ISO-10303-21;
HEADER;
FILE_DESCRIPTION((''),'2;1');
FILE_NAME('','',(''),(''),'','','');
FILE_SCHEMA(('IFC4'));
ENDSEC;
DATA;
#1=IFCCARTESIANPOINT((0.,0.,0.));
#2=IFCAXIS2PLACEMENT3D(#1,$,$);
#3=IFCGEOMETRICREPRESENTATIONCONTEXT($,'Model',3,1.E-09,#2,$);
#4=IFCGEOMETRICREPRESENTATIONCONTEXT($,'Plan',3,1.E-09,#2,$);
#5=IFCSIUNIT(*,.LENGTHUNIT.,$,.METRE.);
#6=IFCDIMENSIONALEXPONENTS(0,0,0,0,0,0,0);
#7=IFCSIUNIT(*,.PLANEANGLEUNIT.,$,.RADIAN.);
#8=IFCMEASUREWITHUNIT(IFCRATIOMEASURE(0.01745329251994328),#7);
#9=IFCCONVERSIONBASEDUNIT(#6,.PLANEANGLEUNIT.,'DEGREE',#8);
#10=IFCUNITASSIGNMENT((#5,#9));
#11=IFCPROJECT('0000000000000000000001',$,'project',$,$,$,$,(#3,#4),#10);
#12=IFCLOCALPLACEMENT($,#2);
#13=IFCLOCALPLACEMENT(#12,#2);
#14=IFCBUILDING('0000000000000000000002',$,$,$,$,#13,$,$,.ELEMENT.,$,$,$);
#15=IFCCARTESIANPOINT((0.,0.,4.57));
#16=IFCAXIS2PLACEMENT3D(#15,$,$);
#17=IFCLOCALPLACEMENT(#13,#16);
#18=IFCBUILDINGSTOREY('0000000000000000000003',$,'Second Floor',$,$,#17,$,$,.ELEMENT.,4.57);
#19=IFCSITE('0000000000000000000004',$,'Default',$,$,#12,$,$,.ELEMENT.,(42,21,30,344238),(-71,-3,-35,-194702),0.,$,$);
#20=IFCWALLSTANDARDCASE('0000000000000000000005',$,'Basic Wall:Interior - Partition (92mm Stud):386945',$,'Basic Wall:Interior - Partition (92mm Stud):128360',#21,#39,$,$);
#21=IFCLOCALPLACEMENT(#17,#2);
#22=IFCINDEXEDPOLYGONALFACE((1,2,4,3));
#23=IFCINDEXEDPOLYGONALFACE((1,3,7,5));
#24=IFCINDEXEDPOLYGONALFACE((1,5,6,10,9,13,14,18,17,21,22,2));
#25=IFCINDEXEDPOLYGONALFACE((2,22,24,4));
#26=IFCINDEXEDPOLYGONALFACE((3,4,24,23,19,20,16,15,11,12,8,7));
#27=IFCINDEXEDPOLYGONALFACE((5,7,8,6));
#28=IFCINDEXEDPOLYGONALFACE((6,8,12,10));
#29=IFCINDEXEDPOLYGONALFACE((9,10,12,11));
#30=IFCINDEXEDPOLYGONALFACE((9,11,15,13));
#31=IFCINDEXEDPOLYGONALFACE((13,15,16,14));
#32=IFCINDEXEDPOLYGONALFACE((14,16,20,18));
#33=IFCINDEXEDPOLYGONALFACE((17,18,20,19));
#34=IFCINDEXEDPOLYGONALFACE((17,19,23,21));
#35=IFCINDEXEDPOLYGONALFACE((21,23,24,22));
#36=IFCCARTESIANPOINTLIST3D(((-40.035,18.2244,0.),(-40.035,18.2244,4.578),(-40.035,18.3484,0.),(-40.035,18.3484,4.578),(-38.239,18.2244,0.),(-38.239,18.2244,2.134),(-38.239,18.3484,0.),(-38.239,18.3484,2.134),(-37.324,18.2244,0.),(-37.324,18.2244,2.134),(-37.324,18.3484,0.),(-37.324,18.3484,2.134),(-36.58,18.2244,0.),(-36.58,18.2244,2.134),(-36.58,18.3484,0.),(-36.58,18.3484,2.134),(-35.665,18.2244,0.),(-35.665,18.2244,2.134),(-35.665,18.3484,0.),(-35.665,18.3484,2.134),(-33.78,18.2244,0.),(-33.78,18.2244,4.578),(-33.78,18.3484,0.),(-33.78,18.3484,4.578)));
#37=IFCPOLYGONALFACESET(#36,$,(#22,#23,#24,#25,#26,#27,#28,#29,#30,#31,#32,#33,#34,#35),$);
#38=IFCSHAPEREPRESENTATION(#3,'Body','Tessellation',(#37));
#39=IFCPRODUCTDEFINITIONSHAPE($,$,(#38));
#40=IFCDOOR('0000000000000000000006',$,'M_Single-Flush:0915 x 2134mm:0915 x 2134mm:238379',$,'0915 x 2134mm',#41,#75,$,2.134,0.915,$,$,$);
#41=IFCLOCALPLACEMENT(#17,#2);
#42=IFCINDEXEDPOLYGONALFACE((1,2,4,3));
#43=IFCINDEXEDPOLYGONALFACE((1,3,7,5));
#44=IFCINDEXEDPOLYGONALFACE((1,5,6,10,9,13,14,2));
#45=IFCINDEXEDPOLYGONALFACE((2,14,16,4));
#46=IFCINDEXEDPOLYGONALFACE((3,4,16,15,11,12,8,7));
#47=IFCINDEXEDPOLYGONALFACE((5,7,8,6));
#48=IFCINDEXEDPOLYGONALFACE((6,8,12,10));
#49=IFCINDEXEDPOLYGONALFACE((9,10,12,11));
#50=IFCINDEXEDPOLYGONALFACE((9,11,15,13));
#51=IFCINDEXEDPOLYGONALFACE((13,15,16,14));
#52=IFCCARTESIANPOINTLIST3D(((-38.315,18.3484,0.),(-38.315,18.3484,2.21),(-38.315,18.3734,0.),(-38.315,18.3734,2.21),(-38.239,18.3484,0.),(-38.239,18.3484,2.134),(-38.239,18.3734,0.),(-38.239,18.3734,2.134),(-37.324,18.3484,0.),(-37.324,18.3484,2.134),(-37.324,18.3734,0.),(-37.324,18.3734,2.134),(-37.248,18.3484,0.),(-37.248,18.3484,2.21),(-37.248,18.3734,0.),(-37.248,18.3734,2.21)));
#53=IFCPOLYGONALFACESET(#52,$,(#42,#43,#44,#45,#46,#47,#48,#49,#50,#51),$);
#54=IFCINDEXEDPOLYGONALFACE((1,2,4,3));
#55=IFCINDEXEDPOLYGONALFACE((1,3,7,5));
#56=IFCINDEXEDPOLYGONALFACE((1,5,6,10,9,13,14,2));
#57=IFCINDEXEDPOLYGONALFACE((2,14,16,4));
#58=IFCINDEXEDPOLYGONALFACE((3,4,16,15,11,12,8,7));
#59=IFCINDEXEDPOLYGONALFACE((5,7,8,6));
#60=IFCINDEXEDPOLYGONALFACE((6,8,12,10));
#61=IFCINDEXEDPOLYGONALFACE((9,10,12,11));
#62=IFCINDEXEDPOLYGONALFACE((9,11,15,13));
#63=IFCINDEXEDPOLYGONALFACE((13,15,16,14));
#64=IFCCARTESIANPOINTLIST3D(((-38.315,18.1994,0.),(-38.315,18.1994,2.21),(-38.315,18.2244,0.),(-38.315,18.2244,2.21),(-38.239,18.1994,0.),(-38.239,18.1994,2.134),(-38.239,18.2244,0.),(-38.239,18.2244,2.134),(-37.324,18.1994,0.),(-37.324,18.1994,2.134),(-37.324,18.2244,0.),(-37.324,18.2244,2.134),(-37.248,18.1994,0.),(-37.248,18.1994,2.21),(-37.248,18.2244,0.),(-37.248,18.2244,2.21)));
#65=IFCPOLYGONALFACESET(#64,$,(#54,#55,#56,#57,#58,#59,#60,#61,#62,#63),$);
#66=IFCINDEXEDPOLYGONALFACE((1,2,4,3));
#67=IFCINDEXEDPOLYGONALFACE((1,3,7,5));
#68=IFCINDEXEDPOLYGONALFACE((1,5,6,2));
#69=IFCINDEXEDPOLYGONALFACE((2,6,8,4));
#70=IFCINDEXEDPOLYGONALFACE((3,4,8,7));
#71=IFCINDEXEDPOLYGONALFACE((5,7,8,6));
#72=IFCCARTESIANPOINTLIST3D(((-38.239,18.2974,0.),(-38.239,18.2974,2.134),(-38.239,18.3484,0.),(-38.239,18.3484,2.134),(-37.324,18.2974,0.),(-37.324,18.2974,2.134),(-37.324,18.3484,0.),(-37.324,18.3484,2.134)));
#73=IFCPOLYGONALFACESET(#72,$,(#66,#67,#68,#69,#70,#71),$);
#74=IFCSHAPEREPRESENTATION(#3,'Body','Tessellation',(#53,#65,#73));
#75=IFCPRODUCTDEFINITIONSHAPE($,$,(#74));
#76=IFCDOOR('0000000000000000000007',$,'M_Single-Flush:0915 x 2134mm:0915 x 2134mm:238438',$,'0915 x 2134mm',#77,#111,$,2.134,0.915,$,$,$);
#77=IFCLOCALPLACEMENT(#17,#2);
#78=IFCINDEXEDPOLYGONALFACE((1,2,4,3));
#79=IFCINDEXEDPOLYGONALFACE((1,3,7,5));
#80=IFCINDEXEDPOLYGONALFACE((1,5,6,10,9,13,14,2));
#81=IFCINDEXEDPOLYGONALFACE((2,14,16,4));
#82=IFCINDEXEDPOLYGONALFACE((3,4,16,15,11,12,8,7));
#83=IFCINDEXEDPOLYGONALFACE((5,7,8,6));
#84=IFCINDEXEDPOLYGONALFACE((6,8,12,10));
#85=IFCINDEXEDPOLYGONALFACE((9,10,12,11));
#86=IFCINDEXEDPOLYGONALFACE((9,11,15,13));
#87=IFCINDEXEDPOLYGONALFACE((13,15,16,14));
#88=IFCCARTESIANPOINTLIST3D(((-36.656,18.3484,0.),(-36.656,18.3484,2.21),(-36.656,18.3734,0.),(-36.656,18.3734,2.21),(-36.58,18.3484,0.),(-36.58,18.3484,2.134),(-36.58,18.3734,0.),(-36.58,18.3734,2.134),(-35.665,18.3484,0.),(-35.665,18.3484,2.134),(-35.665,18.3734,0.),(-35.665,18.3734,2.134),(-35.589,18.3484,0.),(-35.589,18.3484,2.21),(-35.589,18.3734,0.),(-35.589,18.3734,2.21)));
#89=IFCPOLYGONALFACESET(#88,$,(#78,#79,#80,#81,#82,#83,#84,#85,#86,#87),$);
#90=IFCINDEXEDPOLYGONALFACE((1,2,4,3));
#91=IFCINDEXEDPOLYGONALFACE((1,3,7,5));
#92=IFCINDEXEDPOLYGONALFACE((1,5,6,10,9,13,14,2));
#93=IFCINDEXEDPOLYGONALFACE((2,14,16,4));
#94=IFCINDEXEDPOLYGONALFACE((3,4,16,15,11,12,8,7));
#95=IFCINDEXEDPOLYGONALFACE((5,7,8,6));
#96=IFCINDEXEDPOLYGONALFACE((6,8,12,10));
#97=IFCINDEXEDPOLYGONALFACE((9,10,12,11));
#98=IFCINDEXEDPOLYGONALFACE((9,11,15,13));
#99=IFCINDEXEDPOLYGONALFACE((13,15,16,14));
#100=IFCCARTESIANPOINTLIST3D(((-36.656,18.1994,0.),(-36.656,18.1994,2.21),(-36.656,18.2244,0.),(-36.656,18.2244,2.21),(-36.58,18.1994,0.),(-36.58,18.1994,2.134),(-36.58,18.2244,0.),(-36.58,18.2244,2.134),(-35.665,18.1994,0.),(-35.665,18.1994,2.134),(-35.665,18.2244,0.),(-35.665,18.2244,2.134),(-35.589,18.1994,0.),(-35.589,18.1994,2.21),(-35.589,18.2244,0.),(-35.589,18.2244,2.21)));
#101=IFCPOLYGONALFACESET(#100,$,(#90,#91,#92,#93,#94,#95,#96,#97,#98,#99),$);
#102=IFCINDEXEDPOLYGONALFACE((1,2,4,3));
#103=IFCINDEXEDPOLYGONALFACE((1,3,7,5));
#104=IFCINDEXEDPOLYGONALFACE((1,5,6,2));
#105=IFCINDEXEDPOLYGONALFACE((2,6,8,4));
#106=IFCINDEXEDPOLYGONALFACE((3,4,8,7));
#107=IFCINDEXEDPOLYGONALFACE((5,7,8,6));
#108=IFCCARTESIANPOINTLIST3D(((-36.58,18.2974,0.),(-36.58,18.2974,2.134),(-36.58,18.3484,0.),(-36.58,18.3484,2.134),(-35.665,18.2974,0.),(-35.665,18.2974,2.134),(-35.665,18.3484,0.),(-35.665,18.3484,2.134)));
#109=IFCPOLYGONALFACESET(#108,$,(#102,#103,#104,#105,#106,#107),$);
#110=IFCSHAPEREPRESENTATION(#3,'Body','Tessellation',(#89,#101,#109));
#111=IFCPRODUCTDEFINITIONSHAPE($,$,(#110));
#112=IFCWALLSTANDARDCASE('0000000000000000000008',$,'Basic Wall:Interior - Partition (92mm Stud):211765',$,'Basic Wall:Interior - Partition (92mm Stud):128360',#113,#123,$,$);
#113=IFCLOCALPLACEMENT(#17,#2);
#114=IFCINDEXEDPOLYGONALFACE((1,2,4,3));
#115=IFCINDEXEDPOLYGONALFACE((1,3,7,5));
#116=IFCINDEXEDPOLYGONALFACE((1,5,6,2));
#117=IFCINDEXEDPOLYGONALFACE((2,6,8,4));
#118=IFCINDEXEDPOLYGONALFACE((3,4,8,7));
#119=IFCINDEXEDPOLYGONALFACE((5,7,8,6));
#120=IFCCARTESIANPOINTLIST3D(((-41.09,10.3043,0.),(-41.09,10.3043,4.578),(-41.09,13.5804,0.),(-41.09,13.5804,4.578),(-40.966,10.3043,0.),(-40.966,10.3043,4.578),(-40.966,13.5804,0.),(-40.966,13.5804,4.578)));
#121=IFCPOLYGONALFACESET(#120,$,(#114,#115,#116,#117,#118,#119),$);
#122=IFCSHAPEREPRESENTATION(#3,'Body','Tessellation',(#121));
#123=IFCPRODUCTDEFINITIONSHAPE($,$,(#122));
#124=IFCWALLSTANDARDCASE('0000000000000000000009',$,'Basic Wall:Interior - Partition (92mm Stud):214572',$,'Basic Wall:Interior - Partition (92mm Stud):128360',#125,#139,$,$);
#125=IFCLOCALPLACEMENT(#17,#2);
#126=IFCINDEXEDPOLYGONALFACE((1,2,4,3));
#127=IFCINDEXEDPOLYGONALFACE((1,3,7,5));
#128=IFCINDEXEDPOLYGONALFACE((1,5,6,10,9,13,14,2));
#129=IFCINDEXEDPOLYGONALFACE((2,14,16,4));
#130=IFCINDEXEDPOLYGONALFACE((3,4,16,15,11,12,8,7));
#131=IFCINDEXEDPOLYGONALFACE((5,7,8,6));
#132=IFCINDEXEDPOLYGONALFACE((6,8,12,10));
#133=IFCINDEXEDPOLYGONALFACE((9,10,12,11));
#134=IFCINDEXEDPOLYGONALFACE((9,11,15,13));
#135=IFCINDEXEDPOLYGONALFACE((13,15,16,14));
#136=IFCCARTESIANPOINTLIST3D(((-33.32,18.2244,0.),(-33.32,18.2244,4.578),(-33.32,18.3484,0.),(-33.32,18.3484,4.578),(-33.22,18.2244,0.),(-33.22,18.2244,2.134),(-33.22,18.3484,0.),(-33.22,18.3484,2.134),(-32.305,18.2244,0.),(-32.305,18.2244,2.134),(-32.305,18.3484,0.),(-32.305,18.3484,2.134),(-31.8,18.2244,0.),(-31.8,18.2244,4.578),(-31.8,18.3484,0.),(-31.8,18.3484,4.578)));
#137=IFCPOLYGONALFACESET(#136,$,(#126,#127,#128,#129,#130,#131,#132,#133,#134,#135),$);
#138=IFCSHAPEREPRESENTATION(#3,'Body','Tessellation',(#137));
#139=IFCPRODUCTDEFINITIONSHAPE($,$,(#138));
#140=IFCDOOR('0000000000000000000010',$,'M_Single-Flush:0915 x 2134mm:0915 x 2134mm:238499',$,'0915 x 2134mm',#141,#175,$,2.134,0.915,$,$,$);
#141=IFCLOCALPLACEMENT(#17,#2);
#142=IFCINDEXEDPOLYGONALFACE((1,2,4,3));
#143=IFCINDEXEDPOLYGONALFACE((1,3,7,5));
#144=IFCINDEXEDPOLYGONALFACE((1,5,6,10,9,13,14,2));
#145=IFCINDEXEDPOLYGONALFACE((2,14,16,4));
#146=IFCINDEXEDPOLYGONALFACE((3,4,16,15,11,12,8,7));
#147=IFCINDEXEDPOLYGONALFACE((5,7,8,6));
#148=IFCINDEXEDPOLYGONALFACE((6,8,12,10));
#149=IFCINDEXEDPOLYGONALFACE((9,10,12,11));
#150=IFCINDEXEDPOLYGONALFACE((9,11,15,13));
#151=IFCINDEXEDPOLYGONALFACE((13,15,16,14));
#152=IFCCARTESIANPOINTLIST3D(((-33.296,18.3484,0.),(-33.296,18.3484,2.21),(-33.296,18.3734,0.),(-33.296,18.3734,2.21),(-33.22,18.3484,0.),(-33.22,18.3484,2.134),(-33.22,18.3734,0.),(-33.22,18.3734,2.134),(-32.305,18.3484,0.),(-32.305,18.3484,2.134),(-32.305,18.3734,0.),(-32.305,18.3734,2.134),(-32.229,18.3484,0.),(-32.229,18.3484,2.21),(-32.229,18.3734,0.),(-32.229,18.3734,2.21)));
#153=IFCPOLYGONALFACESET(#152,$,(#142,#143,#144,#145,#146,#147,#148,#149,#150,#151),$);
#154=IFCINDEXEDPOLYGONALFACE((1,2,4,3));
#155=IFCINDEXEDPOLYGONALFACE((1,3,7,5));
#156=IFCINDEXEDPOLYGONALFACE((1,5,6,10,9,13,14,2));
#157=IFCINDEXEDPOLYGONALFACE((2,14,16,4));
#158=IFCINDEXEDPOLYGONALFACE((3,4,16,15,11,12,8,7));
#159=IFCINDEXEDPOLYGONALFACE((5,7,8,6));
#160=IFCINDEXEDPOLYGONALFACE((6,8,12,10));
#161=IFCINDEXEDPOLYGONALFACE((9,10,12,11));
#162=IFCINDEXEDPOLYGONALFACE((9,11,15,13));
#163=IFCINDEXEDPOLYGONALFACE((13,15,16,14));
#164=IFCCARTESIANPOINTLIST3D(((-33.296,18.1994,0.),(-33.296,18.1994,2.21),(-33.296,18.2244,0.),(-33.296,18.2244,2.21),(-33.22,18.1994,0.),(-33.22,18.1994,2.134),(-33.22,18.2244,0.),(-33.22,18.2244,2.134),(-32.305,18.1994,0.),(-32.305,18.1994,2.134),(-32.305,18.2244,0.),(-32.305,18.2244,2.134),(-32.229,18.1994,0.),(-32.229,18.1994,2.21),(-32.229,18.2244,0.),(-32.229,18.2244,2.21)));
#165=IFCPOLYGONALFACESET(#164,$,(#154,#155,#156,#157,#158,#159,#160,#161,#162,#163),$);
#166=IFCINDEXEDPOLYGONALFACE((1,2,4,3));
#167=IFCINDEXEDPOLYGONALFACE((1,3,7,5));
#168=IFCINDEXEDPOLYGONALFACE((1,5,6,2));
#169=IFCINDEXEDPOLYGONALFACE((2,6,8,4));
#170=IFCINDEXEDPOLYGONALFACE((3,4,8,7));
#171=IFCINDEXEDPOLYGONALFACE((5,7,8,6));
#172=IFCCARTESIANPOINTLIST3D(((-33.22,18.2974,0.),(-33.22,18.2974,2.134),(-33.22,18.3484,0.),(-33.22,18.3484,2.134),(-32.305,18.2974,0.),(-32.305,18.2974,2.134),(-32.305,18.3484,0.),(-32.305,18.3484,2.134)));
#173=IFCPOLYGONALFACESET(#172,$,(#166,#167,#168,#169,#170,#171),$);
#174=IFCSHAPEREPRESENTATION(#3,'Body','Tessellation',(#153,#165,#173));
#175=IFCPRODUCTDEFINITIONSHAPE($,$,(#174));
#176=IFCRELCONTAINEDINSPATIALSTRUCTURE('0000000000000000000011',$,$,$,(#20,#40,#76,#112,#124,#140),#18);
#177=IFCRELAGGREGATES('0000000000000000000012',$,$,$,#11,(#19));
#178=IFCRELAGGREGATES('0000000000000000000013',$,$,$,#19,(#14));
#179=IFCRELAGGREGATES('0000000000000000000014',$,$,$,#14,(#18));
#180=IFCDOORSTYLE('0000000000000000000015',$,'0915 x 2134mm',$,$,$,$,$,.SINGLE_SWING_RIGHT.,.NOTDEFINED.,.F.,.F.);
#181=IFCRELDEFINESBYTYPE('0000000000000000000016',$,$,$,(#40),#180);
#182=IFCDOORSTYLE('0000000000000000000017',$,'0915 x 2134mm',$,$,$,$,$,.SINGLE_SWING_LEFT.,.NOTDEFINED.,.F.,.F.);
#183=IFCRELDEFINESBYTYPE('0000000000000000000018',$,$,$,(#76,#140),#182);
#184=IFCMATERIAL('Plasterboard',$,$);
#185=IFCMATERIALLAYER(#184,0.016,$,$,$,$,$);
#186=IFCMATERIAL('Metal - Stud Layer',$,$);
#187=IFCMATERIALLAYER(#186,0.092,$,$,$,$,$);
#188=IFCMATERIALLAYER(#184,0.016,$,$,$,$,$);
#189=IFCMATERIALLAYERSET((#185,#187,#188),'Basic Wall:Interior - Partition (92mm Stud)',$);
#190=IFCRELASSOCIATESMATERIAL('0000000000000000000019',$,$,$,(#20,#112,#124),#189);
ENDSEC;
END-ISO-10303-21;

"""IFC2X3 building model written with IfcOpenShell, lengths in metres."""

from ifc_helpers import new_model, entity, si_unit, converted_unit, frame, frame_2d, origin, origin_2d_with_axis, place, context, project, spatial, polyline, rectangle, outline, extrude, source, transform, mapped, material, layer, layer_set, layer_usage, type_object, type_shapes, element, fill, save


model = new_model("IFC2X3")

# Units and contexts
model_context = context("Model", 3, precision=1e-09, world=origin())
plan_context = context("Plan", 3, precision=1e-09, world=origin())
ifc_project = project(units=[si_unit("LENGTHUNIT", "METRE"), converted_unit("PLANEANGLEUNIT", "DEGREE", entity("IfcRatioMeasure", 0.01745329251994328), si_unit("PLANEANGLEUNIT", "RADIAN"), dimensions=[0, 0, 0, 0, 0, 0, 0])], contexts=[model_context, plan_context])

# Site, building, storey
site_placement = place(None, origin())
site = spatial("IfcSite", under=ifc_project, at=site_placement, Name="Default", CompositionType="ELEMENT", RefLatitude=(42, 21, 30, 344238), RefLongitude=(-71, -3, -35, -194702), RefElevation=0.0)
building_placement = place(site_placement, origin())
building = spatial("IfcBuilding", under=site, at=building_placement, CompositionType="ELEMENT")
storey_placement = place(building_placement, frame((0.0, 0.0, 4.57)))
storey = spatial("IfcBuildingStorey", under=building, at=storey_placement, Name="Second Floor", CompositionType="ELEMENT", Elevation=4.57)

# Wall, openings, doors
ifc_material_1 = material(Name="Plasterboard")
ifc_layer_1 = layer(ifc_material_1, 0.016)
ifc_material_2 = material(Name="Metal - Stud Layer")
ifc_layer_2 = layer(ifc_material_2, 0.092)
ifc_layer_3 = layer(ifc_material_1, 0.016)
ifc_layer_set_1 = layer_set([ifc_layer_1, ifc_layer_2, ifc_layer_3], Name="Basic Wall:Interior - Partition (92mm Stud)")
ifc_layer_usage_1 = layer_usage(ifc_layer_set_1, "AXIS2", "NEGATIVE", 0.062)
wall_1_placement = place(storey_placement, frame((-33.78, 18.2864, 0.0), z_axis=(0.0, 0.0, 1.0), x_axis=(-1.0, 0.0, 0.0)))
wall_1 = element("IfcWallStandardCase", 1, at=wall_1_placement, inside=storey, material=ifc_layer_usage_1, Name="Basic Wall:Interior - Partition (92mm Stud):386945", ObjectType="Basic Wall:Interior - Partition (92mm Stud):128360", context=model_context, shape_type="SweptSolid", body=[
    extrude(rectangle(XDim=6.255, YDim=0.124, at=frame_2d((3.1275, 0.0), x_axis=(-1.0, 0.0))), origin(), (0.0, 0.0, 1.0), 4.578),
])
opening_1_placement = place(wall_1_placement, frame((2.8, 0.062, 0.0)))
opening_1 = element("IfcOpeningElement", 2, at=opening_1_placement, cuts=wall_1, ObjectType="Opening", context=model_context, shape_type="SweptSolid", body=[
    extrude(rectangle(XDim=0.915, YDim=2.134, at=frame_2d((1.067, 0.4575), x_axis=(0.0, -1.0))), frame((0.0, 0.0, 0.0), z_axis=(0.0, -1.0, 0.0), x_axis=(0.0, 0.0, 1.0)), (0.0, 0.0, 1.0), 0.124),
])
opening_2_placement = place(wall_1_placement, frame((4.459, 0.062, 0.0)))
opening_2 = element("IfcOpeningElement", 3, at=opening_2_placement, cuts=wall_1, ObjectType="Opening", context=model_context, shape_type="SweptSolid", body=[
    extrude(rectangle(XDim=0.915, YDim=2.134, at=frame_2d((1.067, 0.4575), x_axis=(0.0, 1.0))), frame((0.0, 0.0, 0.0), z_axis=(0.0, -1.0, 0.0), x_axis=(0.0, 0.0, 1.0)), (0.0, 0.0, 1.0), 0.124),
])
door_style_1 = type_object("IfcDoorStyle", Name="0915 x 2134mm", ConstructionType="NOTDEFINED", OperationType="SINGLE_SWING_RIGHT", ParameterTakesPrecedence=False, Sizeable=False)
shared_shape_1 = source(origin(), model_context, "Body", "SweptSolid", [
    extrude(outline(polyline([(-0.5335, -1.124), (0.5335, -1.124), (0.5335, 1.086), (0.4575, 1.086), (0.4575, -1.048), (-0.4575, -1.048), (-0.4575, 1.086), (-0.5335, 1.086), (-0.5335, -1.124)])), frame((0.4575, 0.124, 1.086), z_axis=(0.0, 1.0, 0.0), x_axis=(1.0, 0.0, 0.0)), (0.0, 0.0, 1.0), 0.025),
    extrude(outline(polyline([(-1.124, -0.5335), (1.086, -0.5335), (1.086, -0.4575), (-1.048, -0.4575), (-1.048, 0.4575), (1.086, 0.4575), (1.086, 0.5335), (-1.124, 0.5335), (-1.124, -0.5335)])), frame((0.4575, -0.025, 1.086), z_axis=(0.0, 1.0, 0.0), x_axis=(0.0, 0.0, -1.0)), (0.0, 0.0, 1.0), 0.025),
    extrude(rectangle(XDim=0.051, YDim=0.915, at=origin_2d_with_axis()), frame((0.4575, 0.0985, 0.0), z_axis=(0.0, 0.0, 1.0), x_axis=(0.0, 1.0, 0.0)), (0.0, 0.0, 1.0), 2.134),
])
type_shapes(door_style_1, [shared_shape_1])
door_1_placement = place(opening_2_placement, frame((0.0, 0.0, 0.0), z_axis=(0.0, 0.0, 1.0), x_axis=(-1.0, 0.0, 0.0)))
door_1 = element("IfcDoor", 4, at=door_1_placement, inside=storey, type_object=door_style_1, Name="M_Single-Flush:0915 x 2134mm:0915 x 2134mm:238379", ObjectType="0915 x 2134mm", OverallHeight=2.134, OverallWidth=0.915, context=model_context, shape_type="MappedRepresentation", body=[
    mapped(shared_shape_1, transform((0.0, 0.0, 0.0), scale=1.0)),
])
fill(opening_2, door_1)
door_style_2 = type_object("IfcDoorStyle", Name="0915 x 2134mm", ConstructionType="NOTDEFINED", OperationType="SINGLE_SWING_LEFT", ParameterTakesPrecedence=False, Sizeable=False)
shared_shape_2 = source(origin(), model_context, "Body", "SweptSolid", [
    extrude(outline(polyline([(-0.5335, -1.124), (0.5335, -1.124), (0.5335, 1.086), (0.4575, 1.086), (0.4575, -1.048), (-0.4575, -1.048), (-0.4575, 1.086), (-0.5335, 1.086), (-0.5335, -1.124)])), frame((0.4575, 0.149, 1.086), z_axis=(0.0, -1.0, 0.0), x_axis=(-1.0, 0.0, 0.0)), (0.0, 0.0, 1.0), 0.025),
    extrude(outline(polyline([(-1.124, -0.5335), (1.086, -0.5335), (1.086, -0.4575), (-1.048, -0.4575), (-1.048, 0.4575), (1.086, 0.4575), (1.086, 0.5335), (-1.124, 0.5335), (-1.124, -0.5335)])), frame((0.4575, 0.0, 1.086), z_axis=(0.0, -1.0, 0.0), x_axis=(0.0, 0.0, -1.0)), (0.0, 0.0, 1.0), 0.025),
    extrude(rectangle(XDim=0.915, YDim=0.051, at=origin_2d_with_axis()), frame((0.4575, 0.0985, 0.0)), (0.0, 0.0, 1.0), 2.134),
])
type_shapes(door_style_2, [shared_shape_2])
door_2_placement = place(opening_1_placement, frame((0.0, 0.0, 0.0), z_axis=(0.0, 0.0, 1.0), x_axis=(-1.0, 0.0, 0.0)))
door_2 = element("IfcDoor", 5, at=door_2_placement, inside=storey, type_object=door_style_2, Name="M_Single-Flush:0915 x 2134mm:0915 x 2134mm:238438", ObjectType="0915 x 2134mm", OverallHeight=2.134, OverallWidth=0.915, context=model_context, shape_type="MappedRepresentation", body=[
    mapped(shared_shape_2, transform((0.0, 0.0, 0.0), scale=1.0)),
])
fill(opening_1, door_2)

# Wall
wall_2_placement = place(storey_placement, frame((-41.028, 10.3043, 0.0), z_axis=(0.0, 0.0, 1.0), x_axis=(0.0, 1.0, 0.0)))
element("IfcWallStandardCase", 6, at=wall_2_placement, inside=storey, material=ifc_layer_usage_1, Name="Basic Wall:Interior - Partition (92mm Stud):211765", ObjectType="Basic Wall:Interior - Partition (92mm Stud):128360", context=model_context, shape_type="SweptSolid", body=[
    extrude(rectangle(XDim=3.2761, YDim=0.124, at=frame_2d((1.6381, 0.0), x_axis=(-1.0, 0.0))), origin(), (0.0, 0.0, 1.0), 4.578),
])

# Wall, opening, door
wall_3_placement = place(storey_placement, frame((-31.8, 18.2864, 0.0), z_axis=(0.0, 0.0, 1.0), x_axis=(-1.0, 0.0, 0.0)))
wall_3 = element("IfcWallStandardCase", 7, at=wall_3_placement, inside=storey, material=ifc_layer_usage_1, Name="Basic Wall:Interior - Partition (92mm Stud):214572", ObjectType="Basic Wall:Interior - Partition (92mm Stud):128360", context=model_context, shape_type="SweptSolid", body=[
    extrude(rectangle(XDim=1.52, YDim=0.124, at=frame_2d((0.76, 0.0), x_axis=(-1.0, 0.0))), origin(), (0.0, 0.0, 1.0), 4.578),
])
opening_3_placement = place(wall_3_placement, frame((1.42, 0.062, 0.0)))
opening_3 = element("IfcOpeningElement", 8, at=opening_3_placement, cuts=wall_3, ObjectType="Opening", context=model_context, shape_type="SweptSolid", body=[
    extrude(rectangle(XDim=0.915, YDim=2.134, at=frame_2d((1.067, 0.4575), x_axis=(0.0, -1.0))), frame((0.0, 0.0, 0.0), z_axis=(0.0, -1.0, 0.0), x_axis=(0.0, 0.0, 1.0)), (0.0, 0.0, 1.0), 0.124),
])
door_3_placement = place(opening_3_placement, frame((0.0, 0.0, 0.0), z_axis=(0.0, 0.0, 1.0), x_axis=(-1.0, 0.0, 0.0)))
door_3 = element("IfcDoor", 9, at=door_3_placement, inside=storey, type_object=door_style_2, Name="M_Single-Flush:0915 x 2134mm:0915 x 2134mm:238499", ObjectType="0915 x 2134mm", OverallHeight=2.134, OverallWidth=0.915, context=model_context, shape_type="MappedRepresentation", body=[
    mapped(shared_shape_2, transform((0.0, 0.0, 0.0), scale=1.0)),
])
fill(opening_3, door_3)

save(model, "model.ifc")
